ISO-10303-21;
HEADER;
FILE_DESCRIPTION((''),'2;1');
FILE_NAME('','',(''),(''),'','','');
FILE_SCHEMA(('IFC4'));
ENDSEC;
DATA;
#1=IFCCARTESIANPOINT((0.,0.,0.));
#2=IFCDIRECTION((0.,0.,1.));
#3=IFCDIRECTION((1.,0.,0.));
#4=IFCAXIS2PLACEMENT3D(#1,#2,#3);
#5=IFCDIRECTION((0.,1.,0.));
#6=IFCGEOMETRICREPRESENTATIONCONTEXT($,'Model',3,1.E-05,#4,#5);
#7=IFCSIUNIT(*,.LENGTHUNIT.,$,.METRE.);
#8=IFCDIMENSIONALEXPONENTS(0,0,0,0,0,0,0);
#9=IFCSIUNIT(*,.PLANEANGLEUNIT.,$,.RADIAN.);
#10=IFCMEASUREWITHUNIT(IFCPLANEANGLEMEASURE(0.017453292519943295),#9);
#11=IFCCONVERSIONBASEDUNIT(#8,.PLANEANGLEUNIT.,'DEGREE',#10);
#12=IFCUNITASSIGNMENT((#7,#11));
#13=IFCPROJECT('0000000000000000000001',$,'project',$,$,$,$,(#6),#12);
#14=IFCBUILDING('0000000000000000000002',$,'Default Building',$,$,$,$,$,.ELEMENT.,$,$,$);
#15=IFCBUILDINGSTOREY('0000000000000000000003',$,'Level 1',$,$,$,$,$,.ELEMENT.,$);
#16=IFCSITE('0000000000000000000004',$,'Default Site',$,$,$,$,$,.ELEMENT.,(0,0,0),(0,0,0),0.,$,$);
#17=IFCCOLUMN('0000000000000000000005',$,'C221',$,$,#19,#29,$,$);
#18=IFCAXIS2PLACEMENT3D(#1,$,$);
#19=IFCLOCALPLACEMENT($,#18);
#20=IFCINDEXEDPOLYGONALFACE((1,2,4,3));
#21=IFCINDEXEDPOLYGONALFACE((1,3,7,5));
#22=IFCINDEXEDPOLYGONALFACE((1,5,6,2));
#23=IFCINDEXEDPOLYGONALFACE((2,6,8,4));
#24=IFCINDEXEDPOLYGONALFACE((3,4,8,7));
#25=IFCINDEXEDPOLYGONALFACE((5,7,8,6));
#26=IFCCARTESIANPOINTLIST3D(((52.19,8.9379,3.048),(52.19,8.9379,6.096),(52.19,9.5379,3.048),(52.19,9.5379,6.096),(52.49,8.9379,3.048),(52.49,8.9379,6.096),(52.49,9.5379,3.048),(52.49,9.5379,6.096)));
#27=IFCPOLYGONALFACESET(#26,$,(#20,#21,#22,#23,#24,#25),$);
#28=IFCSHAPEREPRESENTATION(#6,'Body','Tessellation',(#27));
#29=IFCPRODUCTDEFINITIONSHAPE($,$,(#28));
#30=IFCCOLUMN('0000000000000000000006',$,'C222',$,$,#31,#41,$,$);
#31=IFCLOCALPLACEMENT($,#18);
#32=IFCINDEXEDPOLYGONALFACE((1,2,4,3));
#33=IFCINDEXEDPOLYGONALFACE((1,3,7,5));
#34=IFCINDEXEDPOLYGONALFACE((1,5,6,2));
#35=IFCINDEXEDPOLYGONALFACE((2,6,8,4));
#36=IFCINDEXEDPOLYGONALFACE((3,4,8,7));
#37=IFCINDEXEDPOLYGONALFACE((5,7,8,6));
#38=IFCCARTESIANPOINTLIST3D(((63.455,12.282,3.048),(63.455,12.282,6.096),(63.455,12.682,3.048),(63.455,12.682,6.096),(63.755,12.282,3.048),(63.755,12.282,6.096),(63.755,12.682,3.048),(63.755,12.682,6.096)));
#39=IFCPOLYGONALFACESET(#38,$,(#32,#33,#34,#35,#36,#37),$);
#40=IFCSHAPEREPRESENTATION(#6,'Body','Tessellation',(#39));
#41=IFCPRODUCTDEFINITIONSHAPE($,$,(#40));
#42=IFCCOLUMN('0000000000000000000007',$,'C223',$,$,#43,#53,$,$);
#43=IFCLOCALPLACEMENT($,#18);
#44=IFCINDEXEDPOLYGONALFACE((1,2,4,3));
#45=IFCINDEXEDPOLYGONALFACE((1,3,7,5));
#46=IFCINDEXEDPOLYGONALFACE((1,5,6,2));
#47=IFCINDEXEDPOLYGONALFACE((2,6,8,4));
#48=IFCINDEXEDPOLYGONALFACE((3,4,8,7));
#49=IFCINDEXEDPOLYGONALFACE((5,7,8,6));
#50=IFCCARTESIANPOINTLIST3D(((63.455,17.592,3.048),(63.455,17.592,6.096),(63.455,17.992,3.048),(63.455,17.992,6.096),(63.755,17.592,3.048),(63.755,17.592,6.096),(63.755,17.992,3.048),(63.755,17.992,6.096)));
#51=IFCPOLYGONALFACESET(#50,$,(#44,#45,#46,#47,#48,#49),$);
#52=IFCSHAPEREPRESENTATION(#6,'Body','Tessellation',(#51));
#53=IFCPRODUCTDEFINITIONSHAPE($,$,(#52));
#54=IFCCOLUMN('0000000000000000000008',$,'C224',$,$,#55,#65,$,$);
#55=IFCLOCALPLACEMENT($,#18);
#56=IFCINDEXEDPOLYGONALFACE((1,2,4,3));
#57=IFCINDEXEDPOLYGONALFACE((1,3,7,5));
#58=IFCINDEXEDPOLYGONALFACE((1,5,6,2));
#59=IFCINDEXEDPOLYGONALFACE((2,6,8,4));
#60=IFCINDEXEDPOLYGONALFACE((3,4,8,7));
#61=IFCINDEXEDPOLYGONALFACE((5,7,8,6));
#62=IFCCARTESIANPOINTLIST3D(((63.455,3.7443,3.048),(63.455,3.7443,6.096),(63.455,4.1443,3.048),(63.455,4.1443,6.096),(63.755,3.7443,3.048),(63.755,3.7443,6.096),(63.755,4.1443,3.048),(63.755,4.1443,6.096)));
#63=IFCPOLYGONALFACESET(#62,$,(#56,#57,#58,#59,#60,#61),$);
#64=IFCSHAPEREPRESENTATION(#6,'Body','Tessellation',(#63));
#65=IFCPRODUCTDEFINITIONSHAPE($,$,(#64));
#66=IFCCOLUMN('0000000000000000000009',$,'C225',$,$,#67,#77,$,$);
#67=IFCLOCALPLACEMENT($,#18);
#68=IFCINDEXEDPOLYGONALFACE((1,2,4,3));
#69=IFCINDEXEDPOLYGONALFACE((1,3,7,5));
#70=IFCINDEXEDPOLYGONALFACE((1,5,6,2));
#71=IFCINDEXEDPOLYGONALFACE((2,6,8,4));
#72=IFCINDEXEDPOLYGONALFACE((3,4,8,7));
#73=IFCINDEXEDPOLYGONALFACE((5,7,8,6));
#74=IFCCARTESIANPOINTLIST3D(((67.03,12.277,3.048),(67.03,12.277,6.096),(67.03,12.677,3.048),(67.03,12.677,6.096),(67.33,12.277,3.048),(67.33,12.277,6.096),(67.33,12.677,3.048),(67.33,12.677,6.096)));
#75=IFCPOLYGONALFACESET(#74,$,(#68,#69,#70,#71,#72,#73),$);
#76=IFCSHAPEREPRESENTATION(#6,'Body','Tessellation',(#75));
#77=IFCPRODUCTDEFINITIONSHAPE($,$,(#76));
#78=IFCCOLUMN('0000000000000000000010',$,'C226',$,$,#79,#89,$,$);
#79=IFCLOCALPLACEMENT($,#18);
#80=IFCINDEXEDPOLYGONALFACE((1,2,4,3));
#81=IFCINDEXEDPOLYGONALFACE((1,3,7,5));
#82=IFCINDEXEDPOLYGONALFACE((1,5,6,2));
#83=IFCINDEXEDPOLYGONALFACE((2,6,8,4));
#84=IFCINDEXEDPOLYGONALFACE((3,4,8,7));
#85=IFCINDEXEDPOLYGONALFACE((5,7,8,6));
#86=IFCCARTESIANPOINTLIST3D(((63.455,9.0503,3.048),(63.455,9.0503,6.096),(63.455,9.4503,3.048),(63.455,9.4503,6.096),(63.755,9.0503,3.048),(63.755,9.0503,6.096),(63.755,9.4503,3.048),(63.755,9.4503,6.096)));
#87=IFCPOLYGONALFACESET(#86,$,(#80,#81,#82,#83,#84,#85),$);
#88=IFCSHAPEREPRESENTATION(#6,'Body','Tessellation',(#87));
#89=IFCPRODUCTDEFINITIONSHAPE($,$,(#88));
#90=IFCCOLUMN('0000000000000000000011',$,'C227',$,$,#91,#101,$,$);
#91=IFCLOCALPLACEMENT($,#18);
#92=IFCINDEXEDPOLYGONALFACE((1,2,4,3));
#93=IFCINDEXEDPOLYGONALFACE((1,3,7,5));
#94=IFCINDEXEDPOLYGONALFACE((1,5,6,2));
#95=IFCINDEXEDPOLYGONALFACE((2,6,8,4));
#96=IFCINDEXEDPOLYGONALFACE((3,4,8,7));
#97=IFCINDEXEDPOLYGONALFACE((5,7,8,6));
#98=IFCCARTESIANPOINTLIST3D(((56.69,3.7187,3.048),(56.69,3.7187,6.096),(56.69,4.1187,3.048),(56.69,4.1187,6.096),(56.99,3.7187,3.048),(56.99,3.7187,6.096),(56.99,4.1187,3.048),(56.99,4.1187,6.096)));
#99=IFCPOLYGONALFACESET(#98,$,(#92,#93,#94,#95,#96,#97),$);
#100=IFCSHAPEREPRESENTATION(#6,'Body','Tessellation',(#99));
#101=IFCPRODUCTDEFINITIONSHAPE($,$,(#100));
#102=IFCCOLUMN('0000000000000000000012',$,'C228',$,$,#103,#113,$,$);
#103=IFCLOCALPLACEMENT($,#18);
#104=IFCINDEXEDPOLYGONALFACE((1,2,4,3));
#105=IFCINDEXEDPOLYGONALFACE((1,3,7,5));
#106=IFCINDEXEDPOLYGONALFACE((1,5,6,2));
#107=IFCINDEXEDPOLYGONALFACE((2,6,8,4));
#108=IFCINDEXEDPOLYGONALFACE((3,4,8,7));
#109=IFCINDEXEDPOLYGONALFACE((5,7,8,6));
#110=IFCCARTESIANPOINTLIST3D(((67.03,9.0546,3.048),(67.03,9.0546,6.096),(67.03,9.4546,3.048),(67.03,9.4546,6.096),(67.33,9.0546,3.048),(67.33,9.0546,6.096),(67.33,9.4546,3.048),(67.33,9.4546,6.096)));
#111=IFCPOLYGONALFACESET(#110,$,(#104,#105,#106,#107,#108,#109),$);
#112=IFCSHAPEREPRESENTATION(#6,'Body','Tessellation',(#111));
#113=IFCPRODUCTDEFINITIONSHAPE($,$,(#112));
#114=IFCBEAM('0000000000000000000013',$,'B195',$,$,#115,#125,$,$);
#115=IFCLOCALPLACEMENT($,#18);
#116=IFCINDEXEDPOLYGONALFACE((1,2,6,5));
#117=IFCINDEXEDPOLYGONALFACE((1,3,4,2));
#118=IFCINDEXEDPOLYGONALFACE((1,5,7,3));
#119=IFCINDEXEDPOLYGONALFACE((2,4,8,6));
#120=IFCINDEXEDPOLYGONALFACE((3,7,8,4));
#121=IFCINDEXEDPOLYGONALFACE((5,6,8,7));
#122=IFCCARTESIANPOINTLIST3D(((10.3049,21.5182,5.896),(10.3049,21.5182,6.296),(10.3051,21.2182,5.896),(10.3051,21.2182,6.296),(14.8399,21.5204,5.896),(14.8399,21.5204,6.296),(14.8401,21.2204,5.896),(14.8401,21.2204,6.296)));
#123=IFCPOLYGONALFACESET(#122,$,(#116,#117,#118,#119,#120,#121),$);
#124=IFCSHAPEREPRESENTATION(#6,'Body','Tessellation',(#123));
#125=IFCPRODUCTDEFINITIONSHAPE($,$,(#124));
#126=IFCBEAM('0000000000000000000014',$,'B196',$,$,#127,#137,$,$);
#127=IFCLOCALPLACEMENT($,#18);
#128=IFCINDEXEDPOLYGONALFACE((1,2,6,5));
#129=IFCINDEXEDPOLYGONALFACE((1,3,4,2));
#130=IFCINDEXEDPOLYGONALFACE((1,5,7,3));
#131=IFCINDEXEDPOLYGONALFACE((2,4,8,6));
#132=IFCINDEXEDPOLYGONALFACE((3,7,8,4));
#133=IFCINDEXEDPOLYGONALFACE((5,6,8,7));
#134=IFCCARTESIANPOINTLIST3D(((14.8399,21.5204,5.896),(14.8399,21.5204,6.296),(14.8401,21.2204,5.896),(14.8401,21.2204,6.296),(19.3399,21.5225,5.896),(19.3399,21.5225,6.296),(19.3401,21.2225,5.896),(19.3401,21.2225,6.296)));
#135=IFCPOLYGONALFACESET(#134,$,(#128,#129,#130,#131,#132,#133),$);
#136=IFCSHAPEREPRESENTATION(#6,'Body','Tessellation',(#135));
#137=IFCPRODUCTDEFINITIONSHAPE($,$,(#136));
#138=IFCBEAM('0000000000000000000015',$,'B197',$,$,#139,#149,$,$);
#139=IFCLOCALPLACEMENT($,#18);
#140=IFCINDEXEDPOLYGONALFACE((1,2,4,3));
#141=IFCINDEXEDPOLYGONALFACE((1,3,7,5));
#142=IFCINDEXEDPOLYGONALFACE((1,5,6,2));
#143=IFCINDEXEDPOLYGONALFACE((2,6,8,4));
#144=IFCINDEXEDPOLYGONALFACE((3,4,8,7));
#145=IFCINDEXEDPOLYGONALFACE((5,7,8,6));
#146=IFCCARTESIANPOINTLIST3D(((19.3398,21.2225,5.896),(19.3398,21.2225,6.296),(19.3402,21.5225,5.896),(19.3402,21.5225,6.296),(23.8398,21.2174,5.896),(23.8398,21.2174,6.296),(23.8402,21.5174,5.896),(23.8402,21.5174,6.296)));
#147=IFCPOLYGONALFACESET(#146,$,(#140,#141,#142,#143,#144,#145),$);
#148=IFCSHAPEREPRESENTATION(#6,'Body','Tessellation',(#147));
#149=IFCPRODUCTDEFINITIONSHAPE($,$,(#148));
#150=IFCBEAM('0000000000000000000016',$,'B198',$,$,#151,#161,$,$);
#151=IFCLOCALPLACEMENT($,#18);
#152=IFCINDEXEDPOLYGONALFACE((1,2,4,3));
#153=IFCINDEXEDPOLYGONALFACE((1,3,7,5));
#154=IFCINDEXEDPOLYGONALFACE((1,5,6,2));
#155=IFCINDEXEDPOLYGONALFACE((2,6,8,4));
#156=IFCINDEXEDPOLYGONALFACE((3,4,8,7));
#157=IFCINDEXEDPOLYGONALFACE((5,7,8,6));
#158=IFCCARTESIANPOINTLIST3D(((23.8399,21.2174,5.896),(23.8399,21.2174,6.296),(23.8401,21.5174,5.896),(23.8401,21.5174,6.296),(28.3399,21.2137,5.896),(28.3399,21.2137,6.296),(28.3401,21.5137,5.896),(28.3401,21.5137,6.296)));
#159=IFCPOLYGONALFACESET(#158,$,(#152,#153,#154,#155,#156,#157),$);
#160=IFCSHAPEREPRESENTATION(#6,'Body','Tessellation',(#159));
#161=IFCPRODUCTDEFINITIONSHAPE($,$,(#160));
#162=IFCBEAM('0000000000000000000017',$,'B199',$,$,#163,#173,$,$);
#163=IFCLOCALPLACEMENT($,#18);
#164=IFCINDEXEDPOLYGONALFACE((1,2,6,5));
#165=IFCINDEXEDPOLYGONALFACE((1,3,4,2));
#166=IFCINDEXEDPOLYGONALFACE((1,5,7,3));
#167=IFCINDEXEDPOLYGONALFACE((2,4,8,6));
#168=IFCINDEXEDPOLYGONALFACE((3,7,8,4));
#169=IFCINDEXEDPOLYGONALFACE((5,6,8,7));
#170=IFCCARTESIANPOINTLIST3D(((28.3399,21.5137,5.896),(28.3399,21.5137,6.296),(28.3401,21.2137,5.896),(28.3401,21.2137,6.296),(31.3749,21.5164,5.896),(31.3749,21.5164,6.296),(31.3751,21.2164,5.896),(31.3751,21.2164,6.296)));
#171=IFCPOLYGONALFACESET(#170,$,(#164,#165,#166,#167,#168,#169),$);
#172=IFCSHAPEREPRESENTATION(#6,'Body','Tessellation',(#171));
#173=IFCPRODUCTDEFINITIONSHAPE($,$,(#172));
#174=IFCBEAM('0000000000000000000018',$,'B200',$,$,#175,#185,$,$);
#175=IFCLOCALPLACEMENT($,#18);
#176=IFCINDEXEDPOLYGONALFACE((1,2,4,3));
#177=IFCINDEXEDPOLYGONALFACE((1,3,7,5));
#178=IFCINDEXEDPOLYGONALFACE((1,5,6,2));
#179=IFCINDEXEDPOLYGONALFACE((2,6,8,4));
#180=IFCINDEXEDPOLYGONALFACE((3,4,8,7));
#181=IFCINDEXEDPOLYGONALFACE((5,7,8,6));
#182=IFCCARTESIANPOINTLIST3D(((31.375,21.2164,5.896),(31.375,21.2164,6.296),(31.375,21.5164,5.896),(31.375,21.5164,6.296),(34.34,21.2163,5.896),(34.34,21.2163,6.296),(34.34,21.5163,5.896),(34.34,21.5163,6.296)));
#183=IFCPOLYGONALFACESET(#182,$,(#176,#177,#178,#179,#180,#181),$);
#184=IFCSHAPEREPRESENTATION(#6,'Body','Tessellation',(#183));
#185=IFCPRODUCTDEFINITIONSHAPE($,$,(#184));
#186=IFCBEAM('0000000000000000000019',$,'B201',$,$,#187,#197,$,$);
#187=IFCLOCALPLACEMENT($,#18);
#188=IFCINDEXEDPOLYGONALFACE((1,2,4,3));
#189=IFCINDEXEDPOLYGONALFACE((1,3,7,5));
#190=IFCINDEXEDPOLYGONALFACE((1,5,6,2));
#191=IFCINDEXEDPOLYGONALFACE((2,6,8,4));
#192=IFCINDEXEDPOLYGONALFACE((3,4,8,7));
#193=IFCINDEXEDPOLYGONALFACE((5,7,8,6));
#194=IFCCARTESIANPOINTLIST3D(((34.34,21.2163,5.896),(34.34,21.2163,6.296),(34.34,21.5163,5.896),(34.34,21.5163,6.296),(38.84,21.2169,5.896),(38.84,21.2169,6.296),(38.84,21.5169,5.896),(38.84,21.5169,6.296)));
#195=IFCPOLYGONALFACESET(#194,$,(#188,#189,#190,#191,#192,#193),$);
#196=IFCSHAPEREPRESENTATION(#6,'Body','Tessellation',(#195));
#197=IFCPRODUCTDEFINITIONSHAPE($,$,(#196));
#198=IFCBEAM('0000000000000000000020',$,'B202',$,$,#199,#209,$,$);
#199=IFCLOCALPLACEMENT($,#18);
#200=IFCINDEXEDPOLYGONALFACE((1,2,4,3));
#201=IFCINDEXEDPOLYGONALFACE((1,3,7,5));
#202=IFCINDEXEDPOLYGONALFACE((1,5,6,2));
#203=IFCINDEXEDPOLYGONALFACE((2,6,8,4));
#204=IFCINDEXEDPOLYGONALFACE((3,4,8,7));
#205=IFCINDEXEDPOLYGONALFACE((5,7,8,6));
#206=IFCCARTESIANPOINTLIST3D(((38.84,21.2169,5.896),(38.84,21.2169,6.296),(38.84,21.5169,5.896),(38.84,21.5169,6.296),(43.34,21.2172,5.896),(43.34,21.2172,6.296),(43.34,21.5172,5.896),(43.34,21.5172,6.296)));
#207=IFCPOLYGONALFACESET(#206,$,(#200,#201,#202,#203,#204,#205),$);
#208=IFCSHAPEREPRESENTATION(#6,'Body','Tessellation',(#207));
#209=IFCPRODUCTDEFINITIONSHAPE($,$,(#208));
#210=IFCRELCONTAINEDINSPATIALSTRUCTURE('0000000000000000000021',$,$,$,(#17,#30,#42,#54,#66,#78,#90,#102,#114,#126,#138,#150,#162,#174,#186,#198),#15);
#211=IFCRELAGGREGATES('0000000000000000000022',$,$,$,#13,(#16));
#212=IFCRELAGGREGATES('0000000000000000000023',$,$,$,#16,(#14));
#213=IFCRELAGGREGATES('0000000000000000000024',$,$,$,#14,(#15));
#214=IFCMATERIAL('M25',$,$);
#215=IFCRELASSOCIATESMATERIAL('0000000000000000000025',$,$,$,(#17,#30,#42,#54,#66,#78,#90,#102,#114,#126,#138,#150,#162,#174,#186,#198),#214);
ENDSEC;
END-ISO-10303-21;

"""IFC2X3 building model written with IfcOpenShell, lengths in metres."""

from ifc_helpers import new_model, entity, si_unit, converted_unit, direction, frame, frame_2d, origin_with_axes, place, context, project, spatial, rectangle, extrude, material, element, save


model = new_model("IFC2X3")

# Units and contexts
model_context = context("Model", 3, precision=1e-05, world=origin_with_axes(), true_north=direction((0.0, 1.0, 0.0)))
ifc_project = project(units=[si_unit("LENGTHUNIT", "METRE"), converted_unit("PLANEANGLEUNIT", "DEGREE", entity("IfcPlaneAngleMeasure", 0.017453292519943295), si_unit("PLANEANGLEUNIT", "RADIAN"), dimensions=[0, 0, 0, 0, 0, 0, 0])], contexts=[model_context])

# Site, building, storey
site = spatial("IfcSite", under=ifc_project, Name="Default Site", CompositionType="ELEMENT", RefLatitude=(0, 0, 0), RefLongitude=(0, 0, 0), RefElevation=0.0)
building = spatial("IfcBuilding", under=site, Name="Default Building", CompositionType="ELEMENT")
storey = spatial("IfcBuildingStorey", under=building, Name="Level 1", CompositionType="ELEMENT")

# Columns
ifc_material = material(Name="M25")
placement = place(None, origin_with_axes())
element("IfcColumn", 1, at=placement, inside=storey, material=ifc_material, Name="C221", context=model_context, shape_type="SweptSolid", body=[
    extrude(rectangle(XDim=0.3, YDim=0.6, at=frame_2d((0.0, 0.0), x_axis=(1.0, 0.0, 0.0))), frame((52.34, 9.2379, 3.048), z_axis=(0.0, 0.0, 1.0), x_axis=(1.0, 0.0, 0.0)), (0.0, 0.0, 1.0), 3.048),
])
element("IfcColumn", 2, at=placement, inside=storey, material=ifc_material, Name="C222", context=model_context, shape_type="SweptSolid", body=[
    extrude(rectangle(XDim=0.3, YDim=0.4, at=frame_2d((0.0, 0.0), x_axis=(1.0, 0.0, 0.0))), frame((63.605, 12.482, 3.048), z_axis=(0.0, 0.0, 1.0), x_axis=(1.0, 0.0, 0.0)), (0.0, 0.0, 1.0), 3.048),
])
element("IfcColumn", 3, at=placement, inside=storey, material=ifc_material, Name="C223", context=model_context, shape_type="SweptSolid", body=[
    extrude(rectangle(XDim=0.3, YDim=0.4, at=frame_2d((0.0, 0.0), x_axis=(1.0, 0.0, 0.0))), frame((63.605, 17.792, 3.048), z_axis=(0.0, 0.0, 1.0), x_axis=(1.0, 0.0, 0.0)), (0.0, 0.0, 1.0), 3.048),
])
element("IfcColumn", 4, at=placement, inside=storey, material=ifc_material, Name="C224", context=model_context, shape_type="SweptSolid", body=[
    extrude(rectangle(XDim=0.3, YDim=0.4, at=frame_2d((0.0, 0.0), x_axis=(1.0, 0.0, 0.0))), frame((63.605, 3.9443, 3.048), z_axis=(0.0, 0.0, 1.0), x_axis=(1.0, 0.0, 0.0)), (0.0, 0.0, 1.0), 3.048),
])
element("IfcColumn", 5, at=placement, inside=storey, material=ifc_material, Name="C225", context=model_context, shape_type="SweptSolid", body=[
    extrude(rectangle(XDim=0.3, YDim=0.4, at=frame_2d((0.0, 0.0), x_axis=(1.0, 0.0, 0.0))), frame((67.18, 12.477, 3.048), z_axis=(0.0, 0.0, 1.0), x_axis=(1.0, 0.0, 0.0)), (0.0, 0.0, 1.0), 3.048),
])
element("IfcColumn", 6, at=placement, inside=storey, material=ifc_material, Name="C226", context=model_context, shape_type="SweptSolid", body=[
    extrude(rectangle(XDim=0.3, YDim=0.4, at=frame_2d((0.0, 0.0), x_axis=(1.0, 0.0, 0.0))), frame((63.605, 9.2503, 3.048), z_axis=(0.0, 0.0, 1.0), x_axis=(1.0, 0.0, 0.0)), (0.0, 0.0, 1.0), 3.048),
])
element("IfcColumn", 7, at=placement, inside=storey, material=ifc_material, Name="C227", context=model_context, shape_type="SweptSolid", body=[
    extrude(rectangle(XDim=0.3, YDim=0.4, at=frame_2d((0.0, 0.0), x_axis=(1.0, 0.0, 0.0))), frame((56.84, 3.9187, 3.048), z_axis=(0.0, 0.0, 1.0), x_axis=(1.0, 0.0, 0.0)), (0.0, 0.0, 1.0), 3.048),
])
element("IfcColumn", 8, at=placement, inside=storey, material=ifc_material, Name="C228", context=model_context, shape_type="SweptSolid", body=[
    extrude(rectangle(XDim=0.3, YDim=0.4, at=frame_2d((0.0, 0.0), x_axis=(1.0, 0.0, 0.0))), frame((67.18, 9.2546, 3.048), z_axis=(0.0, 0.0, 1.0), x_axis=(1.0, 0.0, 0.0)), (0.0, 0.0, 1.0), 3.048),
])

# Beams
element("IfcBeam", 9, at=placement, inside=storey, material=ifc_material, Name="B195", context=model_context, shape_type="SweptSolid", body=[
    extrude(rectangle(XDim=0.3, YDim=0.4, at=frame_2d((0.0, 0.0), x_axis=(0.0, 1.0, 0.0))), frame((10.305, 21.3682, 6.096), z_axis=(1.0, 0.000476, 0.0), x_axis=(0.0, 0.0, -1.0)), (0.0, 0.0, 1.0), 4.535),
])
element("IfcBeam", 10, at=placement, inside=storey, material=ifc_material, Name="B196", context=model_context, shape_type="SweptSolid", body=[
    extrude(rectangle(XDim=0.3, YDim=0.4, at=frame_2d((0.0, 0.0), x_axis=(0.0, 1.0, 0.0))), frame((14.84, 21.3704, 6.096), z_axis=(1.0, 0.000471, 0.0), x_axis=(0.0, 0.0, -1.0)), (0.0, 0.0, 1.0), 4.5),
])
element("IfcBeam", 11, at=placement, inside=storey, material=ifc_material, Name="B197", context=model_context, shape_type="SweptSolid", body=[
    extrude(rectangle(XDim=0.3, YDim=0.4, at=frame_2d((0.0, 0.0), x_axis=(0.0, 1.0, 0.0))), frame((19.34, 21.3725, 6.096), z_axis=(0.999999, -0.001141, 0.0), x_axis=(0.0, 0.0, -1.0)), (0.0, 0.0, 1.0), 4.5),
])
element("IfcBeam", 12, at=placement, inside=storey, material=ifc_material, Name="B198", context=model_context, shape_type="SweptSolid", body=[
    extrude(rectangle(XDim=0.3, YDim=0.4, at=frame_2d((0.0, 0.0), x_axis=(0.0, 1.0, 0.0))), frame((23.84, 21.3674, 6.096), z_axis=(1.0, -0.000812, 0.0), x_axis=(0.0, 0.0, -1.0)), (0.0, 0.0, 1.0), 4.5),
])
element("IfcBeam", 13, at=placement, inside=storey, material=ifc_material, Name="B199", context=model_context, shape_type="SweptSolid", body=[
    extrude(rectangle(XDim=0.3, YDim=0.4, at=frame_2d((0.0, 0.0), x_axis=(0.0, 1.0, 0.0))), frame((28.34, 21.3637, 6.096), z_axis=(1.0, 0.000883, 0.0), x_axis=(0.0, 0.0, -1.0)), (0.0, 0.0, 1.0), 3.035),
])
element("IfcBeam", 14, at=placement, inside=storey, material=ifc_material, Name="B200", context=model_context, shape_type="SweptSolid", body=[
    extrude(rectangle(XDim=0.3, YDim=0.4, at=frame_2d((0.0, 0.0), x_axis=(0.0, 1.0, 0.0))), frame((31.375, 21.3664, 6.096), z_axis=(1.0, -0.000016, 0.0), x_axis=(0.0, 0.0, -1.0)), (0.0, 0.0, 1.0), 2.965),
])
element("IfcBeam", 15, at=placement, inside=storey, material=ifc_material, Name="B201", context=model_context, shape_type="SweptSolid", body=[
    extrude(rectangle(XDim=0.3, YDim=0.4, at=frame_2d((0.0, 0.0), x_axis=(0.0, 1.0, 0.0))), frame((34.34, 21.3663, 6.096), z_axis=(1.0, 0.000136, 0.0), x_axis=(0.0, 0.0, -1.0)), (0.0, 0.0, 1.0), 4.5),
])
element("IfcBeam", 16, at=placement, inside=storey, material=ifc_material, Name="B202", context=model_context, shape_type="SweptSolid", body=[
    extrude(rectangle(XDim=0.3, YDim=0.4, at=frame_2d((0.0, 0.0), x_axis=(0.0, 1.0, 0.0))), frame((38.84, 21.3669, 6.096), z_axis=(1.0, 0.00005, 0.0), x_axis=(0.0, 0.0, -1.0)), (0.0, 0.0, 1.0), 4.5),
])

save(model, "model.ifc")
